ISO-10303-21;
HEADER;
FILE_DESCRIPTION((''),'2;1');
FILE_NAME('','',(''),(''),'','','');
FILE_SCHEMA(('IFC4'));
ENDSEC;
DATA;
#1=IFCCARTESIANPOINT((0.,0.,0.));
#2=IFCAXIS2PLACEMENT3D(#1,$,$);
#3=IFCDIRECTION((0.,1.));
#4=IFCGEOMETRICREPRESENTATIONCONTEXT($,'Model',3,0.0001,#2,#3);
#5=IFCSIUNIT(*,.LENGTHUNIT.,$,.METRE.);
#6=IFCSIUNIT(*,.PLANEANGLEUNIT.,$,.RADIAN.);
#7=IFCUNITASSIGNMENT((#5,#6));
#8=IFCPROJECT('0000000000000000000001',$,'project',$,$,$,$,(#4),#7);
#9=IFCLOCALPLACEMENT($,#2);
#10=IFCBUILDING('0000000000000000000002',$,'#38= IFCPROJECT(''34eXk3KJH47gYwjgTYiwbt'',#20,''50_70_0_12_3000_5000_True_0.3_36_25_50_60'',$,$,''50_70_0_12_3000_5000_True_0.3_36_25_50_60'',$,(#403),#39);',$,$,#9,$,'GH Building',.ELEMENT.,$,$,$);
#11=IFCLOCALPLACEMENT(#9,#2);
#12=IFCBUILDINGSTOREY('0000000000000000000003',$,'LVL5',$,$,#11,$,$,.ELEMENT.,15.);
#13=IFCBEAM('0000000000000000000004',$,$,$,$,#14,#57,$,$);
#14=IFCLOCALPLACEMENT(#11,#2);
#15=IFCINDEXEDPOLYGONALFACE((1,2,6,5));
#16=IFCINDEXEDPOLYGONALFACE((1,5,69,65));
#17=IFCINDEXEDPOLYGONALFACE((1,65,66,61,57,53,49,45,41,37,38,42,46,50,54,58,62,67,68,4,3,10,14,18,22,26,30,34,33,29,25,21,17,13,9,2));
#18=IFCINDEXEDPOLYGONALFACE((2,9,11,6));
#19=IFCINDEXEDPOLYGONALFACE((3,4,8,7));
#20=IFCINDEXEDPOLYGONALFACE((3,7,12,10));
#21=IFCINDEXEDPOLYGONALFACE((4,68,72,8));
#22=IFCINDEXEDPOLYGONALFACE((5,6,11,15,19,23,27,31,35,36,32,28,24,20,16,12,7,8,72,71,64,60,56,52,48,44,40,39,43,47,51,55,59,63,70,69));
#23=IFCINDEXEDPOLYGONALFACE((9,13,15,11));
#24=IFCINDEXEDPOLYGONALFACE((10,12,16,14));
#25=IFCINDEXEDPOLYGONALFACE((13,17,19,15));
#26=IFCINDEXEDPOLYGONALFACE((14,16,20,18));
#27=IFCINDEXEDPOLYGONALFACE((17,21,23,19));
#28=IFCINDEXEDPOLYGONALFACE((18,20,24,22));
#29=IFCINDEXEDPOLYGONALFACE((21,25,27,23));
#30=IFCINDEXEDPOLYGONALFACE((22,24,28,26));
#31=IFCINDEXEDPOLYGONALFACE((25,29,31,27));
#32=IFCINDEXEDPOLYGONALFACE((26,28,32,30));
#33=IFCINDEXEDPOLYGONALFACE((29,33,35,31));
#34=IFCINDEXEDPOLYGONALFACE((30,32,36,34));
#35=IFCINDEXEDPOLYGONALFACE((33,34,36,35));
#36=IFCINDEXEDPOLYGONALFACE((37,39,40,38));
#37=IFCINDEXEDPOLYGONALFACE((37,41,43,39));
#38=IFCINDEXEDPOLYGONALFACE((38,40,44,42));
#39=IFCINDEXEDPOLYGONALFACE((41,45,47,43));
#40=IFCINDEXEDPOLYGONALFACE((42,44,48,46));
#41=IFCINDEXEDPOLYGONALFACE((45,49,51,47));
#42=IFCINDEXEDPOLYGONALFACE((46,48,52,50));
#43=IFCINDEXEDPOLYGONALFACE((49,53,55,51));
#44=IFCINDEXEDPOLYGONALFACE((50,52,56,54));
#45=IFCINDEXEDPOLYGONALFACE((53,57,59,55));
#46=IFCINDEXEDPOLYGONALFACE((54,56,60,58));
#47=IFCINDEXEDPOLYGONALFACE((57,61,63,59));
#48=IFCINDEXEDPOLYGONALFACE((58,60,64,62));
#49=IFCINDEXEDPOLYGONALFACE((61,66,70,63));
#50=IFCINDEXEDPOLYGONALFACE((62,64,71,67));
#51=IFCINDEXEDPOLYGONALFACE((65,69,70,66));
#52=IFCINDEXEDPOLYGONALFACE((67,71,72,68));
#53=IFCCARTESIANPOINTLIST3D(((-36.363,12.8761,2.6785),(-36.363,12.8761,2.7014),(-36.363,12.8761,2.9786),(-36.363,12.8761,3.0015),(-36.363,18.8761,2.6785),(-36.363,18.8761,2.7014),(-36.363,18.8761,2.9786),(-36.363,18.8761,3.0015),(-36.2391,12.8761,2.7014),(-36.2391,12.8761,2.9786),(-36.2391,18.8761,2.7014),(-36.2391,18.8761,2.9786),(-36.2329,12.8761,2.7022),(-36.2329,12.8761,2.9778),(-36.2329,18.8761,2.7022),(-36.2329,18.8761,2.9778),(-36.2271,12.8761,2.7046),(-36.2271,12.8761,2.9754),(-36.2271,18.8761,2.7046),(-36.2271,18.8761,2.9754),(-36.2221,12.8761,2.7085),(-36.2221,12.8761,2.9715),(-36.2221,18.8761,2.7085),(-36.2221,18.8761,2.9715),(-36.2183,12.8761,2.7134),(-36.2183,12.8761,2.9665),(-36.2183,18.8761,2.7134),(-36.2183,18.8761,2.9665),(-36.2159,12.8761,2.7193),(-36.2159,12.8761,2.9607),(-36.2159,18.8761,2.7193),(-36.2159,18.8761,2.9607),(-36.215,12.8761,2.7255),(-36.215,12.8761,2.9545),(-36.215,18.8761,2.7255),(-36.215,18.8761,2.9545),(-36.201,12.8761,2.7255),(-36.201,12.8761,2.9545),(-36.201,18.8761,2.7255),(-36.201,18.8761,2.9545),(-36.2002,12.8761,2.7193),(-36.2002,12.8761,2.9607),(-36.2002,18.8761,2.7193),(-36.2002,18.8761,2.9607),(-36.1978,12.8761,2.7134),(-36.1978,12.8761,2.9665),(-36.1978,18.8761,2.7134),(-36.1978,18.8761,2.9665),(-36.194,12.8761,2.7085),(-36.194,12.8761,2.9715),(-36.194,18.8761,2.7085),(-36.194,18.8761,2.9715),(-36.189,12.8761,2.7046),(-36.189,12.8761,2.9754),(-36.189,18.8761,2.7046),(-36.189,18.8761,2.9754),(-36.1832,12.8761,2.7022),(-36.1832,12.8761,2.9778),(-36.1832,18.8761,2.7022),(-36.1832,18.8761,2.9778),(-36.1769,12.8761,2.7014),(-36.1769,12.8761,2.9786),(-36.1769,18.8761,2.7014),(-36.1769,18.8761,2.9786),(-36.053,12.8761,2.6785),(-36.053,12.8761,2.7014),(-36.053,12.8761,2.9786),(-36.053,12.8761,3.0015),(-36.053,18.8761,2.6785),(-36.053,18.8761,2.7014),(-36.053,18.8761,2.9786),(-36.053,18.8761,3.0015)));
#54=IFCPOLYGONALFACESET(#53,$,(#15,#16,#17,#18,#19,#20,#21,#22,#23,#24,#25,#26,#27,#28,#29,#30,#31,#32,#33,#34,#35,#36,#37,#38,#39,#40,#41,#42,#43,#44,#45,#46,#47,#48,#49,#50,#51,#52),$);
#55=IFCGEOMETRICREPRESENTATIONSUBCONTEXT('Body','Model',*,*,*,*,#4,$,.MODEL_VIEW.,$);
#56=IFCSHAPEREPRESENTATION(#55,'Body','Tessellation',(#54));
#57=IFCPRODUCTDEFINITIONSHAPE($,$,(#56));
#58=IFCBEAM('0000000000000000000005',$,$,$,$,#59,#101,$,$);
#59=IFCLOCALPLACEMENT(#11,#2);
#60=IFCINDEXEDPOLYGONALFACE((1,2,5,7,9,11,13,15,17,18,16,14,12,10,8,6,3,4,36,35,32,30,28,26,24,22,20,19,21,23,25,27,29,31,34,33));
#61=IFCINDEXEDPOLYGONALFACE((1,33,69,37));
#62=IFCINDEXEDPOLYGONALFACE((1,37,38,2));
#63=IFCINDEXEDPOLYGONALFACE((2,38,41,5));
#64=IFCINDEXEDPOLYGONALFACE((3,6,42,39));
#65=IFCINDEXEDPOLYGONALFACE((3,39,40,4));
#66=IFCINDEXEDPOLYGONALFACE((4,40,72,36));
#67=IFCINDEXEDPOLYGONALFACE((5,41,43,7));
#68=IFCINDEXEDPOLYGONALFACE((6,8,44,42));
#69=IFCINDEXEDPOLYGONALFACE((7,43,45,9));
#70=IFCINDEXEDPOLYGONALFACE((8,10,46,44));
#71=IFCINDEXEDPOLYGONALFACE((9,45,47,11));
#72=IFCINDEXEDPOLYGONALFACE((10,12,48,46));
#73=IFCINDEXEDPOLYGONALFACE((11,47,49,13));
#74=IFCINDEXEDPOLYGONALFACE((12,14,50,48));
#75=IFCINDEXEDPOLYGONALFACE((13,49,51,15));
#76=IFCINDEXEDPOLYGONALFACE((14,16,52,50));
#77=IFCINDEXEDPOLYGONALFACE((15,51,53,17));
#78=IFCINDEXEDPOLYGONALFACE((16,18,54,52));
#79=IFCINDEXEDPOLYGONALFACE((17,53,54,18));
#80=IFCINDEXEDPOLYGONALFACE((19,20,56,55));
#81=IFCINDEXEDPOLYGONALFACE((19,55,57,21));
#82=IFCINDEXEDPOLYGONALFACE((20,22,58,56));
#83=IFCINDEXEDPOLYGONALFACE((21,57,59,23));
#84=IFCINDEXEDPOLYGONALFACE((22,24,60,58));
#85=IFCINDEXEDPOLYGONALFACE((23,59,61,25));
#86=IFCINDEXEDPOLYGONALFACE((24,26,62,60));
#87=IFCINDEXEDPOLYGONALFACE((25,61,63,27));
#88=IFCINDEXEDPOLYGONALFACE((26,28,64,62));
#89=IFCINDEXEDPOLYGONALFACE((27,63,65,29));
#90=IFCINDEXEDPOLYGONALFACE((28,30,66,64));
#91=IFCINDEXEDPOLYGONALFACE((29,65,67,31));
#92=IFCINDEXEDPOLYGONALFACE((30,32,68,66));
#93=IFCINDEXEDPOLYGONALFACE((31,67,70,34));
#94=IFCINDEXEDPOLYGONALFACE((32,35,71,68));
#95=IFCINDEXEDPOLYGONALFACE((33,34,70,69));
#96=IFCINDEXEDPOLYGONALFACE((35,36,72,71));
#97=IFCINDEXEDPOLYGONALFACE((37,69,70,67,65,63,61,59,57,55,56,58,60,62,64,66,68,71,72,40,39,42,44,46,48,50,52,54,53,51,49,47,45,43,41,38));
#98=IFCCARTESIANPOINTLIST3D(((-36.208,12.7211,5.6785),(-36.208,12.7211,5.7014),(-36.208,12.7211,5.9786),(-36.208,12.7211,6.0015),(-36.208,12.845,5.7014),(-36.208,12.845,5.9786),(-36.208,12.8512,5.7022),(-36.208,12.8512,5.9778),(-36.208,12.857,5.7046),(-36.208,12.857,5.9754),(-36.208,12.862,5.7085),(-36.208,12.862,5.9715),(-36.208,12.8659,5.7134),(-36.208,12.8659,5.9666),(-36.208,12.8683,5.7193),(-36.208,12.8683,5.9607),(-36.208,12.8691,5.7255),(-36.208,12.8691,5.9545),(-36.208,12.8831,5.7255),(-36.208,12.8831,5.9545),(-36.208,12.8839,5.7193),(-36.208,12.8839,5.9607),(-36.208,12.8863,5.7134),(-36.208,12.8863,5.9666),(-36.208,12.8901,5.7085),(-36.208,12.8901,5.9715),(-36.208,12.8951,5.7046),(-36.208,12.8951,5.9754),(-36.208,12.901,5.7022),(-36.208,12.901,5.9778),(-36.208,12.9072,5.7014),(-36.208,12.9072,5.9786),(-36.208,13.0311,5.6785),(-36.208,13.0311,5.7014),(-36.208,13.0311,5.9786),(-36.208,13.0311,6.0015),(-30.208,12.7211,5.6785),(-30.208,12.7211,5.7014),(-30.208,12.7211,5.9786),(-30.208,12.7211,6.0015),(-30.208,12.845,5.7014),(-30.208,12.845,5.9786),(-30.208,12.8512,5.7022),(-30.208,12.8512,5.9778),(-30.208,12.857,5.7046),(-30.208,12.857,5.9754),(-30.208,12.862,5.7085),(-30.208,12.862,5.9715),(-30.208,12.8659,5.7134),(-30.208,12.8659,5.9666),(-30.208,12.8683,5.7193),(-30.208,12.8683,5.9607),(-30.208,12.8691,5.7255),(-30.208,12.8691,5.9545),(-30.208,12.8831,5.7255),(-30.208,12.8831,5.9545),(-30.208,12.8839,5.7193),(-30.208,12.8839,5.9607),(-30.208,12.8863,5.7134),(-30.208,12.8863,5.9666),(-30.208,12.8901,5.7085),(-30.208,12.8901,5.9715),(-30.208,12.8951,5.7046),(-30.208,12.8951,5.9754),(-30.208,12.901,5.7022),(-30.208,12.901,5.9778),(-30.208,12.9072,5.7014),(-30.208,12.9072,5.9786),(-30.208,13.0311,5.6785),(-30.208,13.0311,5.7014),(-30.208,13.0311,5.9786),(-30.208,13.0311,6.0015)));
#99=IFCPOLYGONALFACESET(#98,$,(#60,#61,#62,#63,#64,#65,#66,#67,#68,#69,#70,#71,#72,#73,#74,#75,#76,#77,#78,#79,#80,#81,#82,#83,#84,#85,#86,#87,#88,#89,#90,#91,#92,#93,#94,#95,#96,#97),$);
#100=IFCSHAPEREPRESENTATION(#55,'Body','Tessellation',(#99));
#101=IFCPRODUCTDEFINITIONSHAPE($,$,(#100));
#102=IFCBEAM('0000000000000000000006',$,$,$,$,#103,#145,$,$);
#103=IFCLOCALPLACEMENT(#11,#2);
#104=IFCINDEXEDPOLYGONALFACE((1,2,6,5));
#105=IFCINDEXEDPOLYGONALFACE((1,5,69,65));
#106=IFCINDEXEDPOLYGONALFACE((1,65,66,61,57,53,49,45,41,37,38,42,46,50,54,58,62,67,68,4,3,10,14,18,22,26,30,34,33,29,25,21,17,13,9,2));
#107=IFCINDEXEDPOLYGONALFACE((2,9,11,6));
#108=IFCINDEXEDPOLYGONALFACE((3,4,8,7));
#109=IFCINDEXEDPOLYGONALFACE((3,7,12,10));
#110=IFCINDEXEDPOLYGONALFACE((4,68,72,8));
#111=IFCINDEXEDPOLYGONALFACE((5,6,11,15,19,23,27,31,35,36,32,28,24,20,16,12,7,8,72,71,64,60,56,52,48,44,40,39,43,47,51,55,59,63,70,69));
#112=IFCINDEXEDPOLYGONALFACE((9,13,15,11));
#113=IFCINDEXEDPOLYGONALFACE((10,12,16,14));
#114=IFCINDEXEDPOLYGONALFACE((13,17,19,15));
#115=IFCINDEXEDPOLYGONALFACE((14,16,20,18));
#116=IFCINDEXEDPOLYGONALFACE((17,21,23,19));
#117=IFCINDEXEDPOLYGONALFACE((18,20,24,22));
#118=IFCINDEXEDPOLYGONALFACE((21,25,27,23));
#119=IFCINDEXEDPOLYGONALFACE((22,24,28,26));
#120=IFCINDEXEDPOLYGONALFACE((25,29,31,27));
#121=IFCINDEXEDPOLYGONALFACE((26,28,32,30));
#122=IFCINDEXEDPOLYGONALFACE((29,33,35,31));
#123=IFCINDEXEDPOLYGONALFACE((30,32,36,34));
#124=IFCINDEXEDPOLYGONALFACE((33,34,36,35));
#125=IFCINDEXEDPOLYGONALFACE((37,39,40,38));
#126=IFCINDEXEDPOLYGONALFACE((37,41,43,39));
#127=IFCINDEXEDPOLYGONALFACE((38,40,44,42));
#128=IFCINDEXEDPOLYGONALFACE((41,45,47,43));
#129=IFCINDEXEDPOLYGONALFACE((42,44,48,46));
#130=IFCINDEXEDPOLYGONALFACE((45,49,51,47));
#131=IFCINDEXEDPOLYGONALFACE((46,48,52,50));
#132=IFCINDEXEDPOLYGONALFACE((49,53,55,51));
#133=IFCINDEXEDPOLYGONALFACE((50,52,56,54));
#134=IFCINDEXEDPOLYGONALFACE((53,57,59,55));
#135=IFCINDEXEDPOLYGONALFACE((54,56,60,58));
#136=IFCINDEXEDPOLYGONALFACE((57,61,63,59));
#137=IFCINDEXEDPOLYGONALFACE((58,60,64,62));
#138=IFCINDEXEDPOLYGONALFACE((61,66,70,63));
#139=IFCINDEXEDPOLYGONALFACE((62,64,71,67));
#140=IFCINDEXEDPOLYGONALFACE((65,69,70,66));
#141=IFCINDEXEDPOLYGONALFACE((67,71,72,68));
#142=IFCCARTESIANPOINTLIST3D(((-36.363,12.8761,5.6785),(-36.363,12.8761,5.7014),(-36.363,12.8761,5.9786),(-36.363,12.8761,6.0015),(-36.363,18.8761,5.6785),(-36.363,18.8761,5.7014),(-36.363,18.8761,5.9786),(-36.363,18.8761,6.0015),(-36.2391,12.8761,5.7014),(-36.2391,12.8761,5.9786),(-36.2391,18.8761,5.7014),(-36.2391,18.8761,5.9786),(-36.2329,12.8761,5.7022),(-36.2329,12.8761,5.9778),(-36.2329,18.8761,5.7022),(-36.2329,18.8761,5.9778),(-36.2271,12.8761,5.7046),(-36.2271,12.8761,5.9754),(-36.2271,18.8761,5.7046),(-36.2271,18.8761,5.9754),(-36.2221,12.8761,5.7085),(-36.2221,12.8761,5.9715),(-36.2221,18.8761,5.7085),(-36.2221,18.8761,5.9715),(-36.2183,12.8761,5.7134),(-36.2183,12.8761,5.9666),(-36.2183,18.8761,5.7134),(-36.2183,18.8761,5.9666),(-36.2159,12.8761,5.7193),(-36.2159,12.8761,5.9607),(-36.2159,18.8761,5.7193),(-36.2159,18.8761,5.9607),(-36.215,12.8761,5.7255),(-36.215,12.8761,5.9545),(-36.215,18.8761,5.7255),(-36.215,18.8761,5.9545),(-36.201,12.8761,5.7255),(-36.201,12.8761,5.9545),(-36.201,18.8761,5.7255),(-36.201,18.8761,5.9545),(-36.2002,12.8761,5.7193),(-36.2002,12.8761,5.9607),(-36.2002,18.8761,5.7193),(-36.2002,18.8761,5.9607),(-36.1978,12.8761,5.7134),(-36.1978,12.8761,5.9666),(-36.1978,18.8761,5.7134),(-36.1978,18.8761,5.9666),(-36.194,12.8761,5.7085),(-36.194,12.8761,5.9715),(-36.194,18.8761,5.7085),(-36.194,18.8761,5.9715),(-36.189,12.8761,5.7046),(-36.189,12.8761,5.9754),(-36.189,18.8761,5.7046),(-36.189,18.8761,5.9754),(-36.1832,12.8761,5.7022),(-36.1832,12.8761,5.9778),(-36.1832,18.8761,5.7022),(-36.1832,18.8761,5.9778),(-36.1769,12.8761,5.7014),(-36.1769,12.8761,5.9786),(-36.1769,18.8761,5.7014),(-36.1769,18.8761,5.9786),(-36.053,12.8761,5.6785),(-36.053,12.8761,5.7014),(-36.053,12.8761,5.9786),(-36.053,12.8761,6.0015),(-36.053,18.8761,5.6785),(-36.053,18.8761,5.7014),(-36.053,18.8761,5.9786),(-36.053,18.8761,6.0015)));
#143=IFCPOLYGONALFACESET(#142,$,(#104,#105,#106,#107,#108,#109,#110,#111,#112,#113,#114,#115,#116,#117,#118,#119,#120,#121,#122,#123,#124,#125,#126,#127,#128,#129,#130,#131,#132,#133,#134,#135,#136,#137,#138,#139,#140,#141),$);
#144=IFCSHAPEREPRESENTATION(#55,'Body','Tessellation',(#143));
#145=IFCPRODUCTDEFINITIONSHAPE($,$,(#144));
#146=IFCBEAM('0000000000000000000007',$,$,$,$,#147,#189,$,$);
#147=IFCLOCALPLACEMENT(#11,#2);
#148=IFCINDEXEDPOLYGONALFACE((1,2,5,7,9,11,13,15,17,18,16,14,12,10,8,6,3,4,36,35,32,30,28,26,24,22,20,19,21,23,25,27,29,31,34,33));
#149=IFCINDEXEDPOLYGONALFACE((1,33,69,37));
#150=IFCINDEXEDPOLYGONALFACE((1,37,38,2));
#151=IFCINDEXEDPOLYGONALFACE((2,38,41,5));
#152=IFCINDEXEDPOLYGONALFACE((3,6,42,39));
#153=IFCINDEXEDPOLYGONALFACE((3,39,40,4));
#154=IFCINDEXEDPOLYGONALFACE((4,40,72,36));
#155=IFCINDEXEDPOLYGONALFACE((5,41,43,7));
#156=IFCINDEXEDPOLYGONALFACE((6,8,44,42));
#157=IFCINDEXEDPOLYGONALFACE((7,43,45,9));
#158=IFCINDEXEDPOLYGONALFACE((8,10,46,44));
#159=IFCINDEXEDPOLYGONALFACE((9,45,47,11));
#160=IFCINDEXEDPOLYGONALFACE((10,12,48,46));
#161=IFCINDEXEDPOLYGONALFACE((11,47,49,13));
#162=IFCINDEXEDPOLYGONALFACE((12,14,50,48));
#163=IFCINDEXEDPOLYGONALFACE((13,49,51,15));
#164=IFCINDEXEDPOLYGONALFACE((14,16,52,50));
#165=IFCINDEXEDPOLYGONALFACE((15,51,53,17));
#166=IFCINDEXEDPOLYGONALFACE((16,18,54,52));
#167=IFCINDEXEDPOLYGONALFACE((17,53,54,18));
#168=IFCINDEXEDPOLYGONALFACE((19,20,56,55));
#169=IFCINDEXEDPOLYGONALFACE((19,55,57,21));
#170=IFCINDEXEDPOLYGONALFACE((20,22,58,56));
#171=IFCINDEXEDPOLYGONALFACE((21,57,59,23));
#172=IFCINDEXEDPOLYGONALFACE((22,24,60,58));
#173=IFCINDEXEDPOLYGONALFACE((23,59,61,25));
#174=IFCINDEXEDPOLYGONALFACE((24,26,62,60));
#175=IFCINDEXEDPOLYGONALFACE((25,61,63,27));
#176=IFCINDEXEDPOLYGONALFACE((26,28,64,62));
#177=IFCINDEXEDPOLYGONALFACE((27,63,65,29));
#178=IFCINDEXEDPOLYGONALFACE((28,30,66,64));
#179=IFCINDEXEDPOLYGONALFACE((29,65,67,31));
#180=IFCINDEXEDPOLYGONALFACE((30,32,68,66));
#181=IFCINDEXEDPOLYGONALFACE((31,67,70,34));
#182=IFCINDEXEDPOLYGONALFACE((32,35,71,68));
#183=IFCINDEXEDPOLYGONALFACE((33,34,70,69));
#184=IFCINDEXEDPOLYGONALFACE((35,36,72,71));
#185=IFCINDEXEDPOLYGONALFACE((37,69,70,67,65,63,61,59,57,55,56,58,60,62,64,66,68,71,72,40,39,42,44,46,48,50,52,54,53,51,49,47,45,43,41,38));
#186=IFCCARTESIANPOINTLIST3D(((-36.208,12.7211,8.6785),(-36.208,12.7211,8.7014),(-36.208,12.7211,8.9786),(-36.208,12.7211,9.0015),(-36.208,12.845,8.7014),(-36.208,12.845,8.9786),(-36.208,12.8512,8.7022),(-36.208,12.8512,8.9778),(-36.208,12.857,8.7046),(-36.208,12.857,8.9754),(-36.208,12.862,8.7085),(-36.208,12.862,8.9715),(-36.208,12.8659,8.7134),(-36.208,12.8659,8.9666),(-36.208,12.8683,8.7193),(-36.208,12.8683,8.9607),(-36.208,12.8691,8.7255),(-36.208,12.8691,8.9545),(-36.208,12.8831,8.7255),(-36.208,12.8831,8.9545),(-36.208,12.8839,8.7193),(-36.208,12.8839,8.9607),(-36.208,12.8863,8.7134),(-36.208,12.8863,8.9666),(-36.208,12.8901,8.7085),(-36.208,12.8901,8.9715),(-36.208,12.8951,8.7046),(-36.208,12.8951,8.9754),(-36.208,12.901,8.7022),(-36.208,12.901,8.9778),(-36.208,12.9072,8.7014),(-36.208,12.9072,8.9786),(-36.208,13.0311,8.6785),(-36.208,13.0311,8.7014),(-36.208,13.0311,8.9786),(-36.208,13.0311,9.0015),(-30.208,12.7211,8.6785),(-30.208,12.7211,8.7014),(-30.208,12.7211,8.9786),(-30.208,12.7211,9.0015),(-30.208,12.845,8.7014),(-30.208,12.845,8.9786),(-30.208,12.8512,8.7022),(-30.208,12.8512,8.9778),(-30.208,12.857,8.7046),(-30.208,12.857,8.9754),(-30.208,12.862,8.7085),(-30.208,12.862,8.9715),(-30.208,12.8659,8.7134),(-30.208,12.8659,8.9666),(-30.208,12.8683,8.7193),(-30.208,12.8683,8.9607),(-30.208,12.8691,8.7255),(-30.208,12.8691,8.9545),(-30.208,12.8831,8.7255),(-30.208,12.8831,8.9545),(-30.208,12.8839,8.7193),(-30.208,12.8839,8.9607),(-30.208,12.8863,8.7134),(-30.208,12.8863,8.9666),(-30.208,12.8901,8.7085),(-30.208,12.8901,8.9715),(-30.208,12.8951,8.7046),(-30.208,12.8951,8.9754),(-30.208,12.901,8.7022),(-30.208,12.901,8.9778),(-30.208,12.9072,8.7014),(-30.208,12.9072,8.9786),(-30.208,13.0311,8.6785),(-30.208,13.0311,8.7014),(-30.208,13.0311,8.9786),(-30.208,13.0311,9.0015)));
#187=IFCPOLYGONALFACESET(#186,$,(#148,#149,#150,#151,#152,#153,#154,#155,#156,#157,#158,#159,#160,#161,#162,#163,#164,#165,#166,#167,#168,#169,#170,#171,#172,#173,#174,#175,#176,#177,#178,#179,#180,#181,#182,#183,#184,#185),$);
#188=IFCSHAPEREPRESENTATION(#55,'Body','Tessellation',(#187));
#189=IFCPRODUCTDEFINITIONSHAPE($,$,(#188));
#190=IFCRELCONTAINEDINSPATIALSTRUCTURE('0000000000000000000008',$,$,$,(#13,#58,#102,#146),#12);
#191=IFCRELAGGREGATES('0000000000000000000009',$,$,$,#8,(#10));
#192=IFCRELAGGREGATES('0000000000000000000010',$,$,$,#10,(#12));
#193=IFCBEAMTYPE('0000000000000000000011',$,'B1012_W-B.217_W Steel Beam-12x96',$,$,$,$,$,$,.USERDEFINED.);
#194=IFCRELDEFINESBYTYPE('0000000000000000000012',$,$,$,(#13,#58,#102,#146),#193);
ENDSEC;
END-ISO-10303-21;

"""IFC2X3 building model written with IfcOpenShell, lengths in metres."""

from ifc_helpers import new_model, si_unit, direction, frame, origin, origin_2d, place, context, subcontext, project, spatial, i_section, extrude, type_object, element, save


model = new_model("IFC2X3")

# Units and contexts
model_context = context("Model", 3, precision=0.0001, world=origin(), true_north=direction((0.0, 1.0)))
body_context = subcontext(model_context, "Body", "Model", "MODEL_VIEW")
ifc_project = project(units=[si_unit("LENGTHUNIT", "METRE"), si_unit("PLANEANGLEUNIT", "RADIAN")], contexts=[model_context])

# Building, storey
building_placement = place(None, origin())
building = spatial("IfcBuilding", under=ifc_project, at=building_placement, Name="#38= IFCPROJECT('34eXk3KJH47gYwjgTYiwbt',#20,'50_70_0_12_3000_5000_True_0.3_36_25_50_60',$,$,'50_70_0_12_3000_5000_True_0.3_36_25_50_60',$,(#403),#39);", LongName="GH Building", CompositionType="ELEMENT")
storey_placement = place(building_placement, origin())
storey = spatial("IfcBuildingStorey", under=building, at=storey_placement, Name="LVL5", CompositionType="ELEMENT", Elevation=15.0)

# Beams
beam_type = type_object("IfcBeamType", Name="B1012_W-B.217_W Steel Beam-12x96", PredefinedType="USERDEFINED")
for number, where, z_axis, x_axis in (
    (1, (-36.208, 12.8761, 2.84), (0.0, 1.0, 0.0), (-1.0, 0.0, 0.0)),
    (2, (-36.208, 12.8761, 5.84), (1.0, 0.0, 0.0), (0.0, 1.0, 0.0)),
    (3, (-36.208, 12.8761, 5.84), (0.0, 1.0, 0.0), (-1.0, 0.0, 0.0)),
    (4, (-36.208, 12.8761, 8.84), (1.0, 0.0, 0.0), (0.0, 1.0, 0.0)),
):
    element("IfcBeam", number, at=place(storey_placement, frame(where, z_axis=z_axis, x_axis=x_axis)), inside=storey, type_object=beam_type, context=body_context, shape_type="SweptSolid", body=[
        extrude(i_section(OverallWidth=0.31, OverallDepth=0.323, WebThickness=0.014, FlangeThickness=0.0229, FilletRadius=0.0241, at=origin_2d()), origin(), (0.0, 0.0, 1.0), 6.0),
    ])

save(model, "model.ifc")
